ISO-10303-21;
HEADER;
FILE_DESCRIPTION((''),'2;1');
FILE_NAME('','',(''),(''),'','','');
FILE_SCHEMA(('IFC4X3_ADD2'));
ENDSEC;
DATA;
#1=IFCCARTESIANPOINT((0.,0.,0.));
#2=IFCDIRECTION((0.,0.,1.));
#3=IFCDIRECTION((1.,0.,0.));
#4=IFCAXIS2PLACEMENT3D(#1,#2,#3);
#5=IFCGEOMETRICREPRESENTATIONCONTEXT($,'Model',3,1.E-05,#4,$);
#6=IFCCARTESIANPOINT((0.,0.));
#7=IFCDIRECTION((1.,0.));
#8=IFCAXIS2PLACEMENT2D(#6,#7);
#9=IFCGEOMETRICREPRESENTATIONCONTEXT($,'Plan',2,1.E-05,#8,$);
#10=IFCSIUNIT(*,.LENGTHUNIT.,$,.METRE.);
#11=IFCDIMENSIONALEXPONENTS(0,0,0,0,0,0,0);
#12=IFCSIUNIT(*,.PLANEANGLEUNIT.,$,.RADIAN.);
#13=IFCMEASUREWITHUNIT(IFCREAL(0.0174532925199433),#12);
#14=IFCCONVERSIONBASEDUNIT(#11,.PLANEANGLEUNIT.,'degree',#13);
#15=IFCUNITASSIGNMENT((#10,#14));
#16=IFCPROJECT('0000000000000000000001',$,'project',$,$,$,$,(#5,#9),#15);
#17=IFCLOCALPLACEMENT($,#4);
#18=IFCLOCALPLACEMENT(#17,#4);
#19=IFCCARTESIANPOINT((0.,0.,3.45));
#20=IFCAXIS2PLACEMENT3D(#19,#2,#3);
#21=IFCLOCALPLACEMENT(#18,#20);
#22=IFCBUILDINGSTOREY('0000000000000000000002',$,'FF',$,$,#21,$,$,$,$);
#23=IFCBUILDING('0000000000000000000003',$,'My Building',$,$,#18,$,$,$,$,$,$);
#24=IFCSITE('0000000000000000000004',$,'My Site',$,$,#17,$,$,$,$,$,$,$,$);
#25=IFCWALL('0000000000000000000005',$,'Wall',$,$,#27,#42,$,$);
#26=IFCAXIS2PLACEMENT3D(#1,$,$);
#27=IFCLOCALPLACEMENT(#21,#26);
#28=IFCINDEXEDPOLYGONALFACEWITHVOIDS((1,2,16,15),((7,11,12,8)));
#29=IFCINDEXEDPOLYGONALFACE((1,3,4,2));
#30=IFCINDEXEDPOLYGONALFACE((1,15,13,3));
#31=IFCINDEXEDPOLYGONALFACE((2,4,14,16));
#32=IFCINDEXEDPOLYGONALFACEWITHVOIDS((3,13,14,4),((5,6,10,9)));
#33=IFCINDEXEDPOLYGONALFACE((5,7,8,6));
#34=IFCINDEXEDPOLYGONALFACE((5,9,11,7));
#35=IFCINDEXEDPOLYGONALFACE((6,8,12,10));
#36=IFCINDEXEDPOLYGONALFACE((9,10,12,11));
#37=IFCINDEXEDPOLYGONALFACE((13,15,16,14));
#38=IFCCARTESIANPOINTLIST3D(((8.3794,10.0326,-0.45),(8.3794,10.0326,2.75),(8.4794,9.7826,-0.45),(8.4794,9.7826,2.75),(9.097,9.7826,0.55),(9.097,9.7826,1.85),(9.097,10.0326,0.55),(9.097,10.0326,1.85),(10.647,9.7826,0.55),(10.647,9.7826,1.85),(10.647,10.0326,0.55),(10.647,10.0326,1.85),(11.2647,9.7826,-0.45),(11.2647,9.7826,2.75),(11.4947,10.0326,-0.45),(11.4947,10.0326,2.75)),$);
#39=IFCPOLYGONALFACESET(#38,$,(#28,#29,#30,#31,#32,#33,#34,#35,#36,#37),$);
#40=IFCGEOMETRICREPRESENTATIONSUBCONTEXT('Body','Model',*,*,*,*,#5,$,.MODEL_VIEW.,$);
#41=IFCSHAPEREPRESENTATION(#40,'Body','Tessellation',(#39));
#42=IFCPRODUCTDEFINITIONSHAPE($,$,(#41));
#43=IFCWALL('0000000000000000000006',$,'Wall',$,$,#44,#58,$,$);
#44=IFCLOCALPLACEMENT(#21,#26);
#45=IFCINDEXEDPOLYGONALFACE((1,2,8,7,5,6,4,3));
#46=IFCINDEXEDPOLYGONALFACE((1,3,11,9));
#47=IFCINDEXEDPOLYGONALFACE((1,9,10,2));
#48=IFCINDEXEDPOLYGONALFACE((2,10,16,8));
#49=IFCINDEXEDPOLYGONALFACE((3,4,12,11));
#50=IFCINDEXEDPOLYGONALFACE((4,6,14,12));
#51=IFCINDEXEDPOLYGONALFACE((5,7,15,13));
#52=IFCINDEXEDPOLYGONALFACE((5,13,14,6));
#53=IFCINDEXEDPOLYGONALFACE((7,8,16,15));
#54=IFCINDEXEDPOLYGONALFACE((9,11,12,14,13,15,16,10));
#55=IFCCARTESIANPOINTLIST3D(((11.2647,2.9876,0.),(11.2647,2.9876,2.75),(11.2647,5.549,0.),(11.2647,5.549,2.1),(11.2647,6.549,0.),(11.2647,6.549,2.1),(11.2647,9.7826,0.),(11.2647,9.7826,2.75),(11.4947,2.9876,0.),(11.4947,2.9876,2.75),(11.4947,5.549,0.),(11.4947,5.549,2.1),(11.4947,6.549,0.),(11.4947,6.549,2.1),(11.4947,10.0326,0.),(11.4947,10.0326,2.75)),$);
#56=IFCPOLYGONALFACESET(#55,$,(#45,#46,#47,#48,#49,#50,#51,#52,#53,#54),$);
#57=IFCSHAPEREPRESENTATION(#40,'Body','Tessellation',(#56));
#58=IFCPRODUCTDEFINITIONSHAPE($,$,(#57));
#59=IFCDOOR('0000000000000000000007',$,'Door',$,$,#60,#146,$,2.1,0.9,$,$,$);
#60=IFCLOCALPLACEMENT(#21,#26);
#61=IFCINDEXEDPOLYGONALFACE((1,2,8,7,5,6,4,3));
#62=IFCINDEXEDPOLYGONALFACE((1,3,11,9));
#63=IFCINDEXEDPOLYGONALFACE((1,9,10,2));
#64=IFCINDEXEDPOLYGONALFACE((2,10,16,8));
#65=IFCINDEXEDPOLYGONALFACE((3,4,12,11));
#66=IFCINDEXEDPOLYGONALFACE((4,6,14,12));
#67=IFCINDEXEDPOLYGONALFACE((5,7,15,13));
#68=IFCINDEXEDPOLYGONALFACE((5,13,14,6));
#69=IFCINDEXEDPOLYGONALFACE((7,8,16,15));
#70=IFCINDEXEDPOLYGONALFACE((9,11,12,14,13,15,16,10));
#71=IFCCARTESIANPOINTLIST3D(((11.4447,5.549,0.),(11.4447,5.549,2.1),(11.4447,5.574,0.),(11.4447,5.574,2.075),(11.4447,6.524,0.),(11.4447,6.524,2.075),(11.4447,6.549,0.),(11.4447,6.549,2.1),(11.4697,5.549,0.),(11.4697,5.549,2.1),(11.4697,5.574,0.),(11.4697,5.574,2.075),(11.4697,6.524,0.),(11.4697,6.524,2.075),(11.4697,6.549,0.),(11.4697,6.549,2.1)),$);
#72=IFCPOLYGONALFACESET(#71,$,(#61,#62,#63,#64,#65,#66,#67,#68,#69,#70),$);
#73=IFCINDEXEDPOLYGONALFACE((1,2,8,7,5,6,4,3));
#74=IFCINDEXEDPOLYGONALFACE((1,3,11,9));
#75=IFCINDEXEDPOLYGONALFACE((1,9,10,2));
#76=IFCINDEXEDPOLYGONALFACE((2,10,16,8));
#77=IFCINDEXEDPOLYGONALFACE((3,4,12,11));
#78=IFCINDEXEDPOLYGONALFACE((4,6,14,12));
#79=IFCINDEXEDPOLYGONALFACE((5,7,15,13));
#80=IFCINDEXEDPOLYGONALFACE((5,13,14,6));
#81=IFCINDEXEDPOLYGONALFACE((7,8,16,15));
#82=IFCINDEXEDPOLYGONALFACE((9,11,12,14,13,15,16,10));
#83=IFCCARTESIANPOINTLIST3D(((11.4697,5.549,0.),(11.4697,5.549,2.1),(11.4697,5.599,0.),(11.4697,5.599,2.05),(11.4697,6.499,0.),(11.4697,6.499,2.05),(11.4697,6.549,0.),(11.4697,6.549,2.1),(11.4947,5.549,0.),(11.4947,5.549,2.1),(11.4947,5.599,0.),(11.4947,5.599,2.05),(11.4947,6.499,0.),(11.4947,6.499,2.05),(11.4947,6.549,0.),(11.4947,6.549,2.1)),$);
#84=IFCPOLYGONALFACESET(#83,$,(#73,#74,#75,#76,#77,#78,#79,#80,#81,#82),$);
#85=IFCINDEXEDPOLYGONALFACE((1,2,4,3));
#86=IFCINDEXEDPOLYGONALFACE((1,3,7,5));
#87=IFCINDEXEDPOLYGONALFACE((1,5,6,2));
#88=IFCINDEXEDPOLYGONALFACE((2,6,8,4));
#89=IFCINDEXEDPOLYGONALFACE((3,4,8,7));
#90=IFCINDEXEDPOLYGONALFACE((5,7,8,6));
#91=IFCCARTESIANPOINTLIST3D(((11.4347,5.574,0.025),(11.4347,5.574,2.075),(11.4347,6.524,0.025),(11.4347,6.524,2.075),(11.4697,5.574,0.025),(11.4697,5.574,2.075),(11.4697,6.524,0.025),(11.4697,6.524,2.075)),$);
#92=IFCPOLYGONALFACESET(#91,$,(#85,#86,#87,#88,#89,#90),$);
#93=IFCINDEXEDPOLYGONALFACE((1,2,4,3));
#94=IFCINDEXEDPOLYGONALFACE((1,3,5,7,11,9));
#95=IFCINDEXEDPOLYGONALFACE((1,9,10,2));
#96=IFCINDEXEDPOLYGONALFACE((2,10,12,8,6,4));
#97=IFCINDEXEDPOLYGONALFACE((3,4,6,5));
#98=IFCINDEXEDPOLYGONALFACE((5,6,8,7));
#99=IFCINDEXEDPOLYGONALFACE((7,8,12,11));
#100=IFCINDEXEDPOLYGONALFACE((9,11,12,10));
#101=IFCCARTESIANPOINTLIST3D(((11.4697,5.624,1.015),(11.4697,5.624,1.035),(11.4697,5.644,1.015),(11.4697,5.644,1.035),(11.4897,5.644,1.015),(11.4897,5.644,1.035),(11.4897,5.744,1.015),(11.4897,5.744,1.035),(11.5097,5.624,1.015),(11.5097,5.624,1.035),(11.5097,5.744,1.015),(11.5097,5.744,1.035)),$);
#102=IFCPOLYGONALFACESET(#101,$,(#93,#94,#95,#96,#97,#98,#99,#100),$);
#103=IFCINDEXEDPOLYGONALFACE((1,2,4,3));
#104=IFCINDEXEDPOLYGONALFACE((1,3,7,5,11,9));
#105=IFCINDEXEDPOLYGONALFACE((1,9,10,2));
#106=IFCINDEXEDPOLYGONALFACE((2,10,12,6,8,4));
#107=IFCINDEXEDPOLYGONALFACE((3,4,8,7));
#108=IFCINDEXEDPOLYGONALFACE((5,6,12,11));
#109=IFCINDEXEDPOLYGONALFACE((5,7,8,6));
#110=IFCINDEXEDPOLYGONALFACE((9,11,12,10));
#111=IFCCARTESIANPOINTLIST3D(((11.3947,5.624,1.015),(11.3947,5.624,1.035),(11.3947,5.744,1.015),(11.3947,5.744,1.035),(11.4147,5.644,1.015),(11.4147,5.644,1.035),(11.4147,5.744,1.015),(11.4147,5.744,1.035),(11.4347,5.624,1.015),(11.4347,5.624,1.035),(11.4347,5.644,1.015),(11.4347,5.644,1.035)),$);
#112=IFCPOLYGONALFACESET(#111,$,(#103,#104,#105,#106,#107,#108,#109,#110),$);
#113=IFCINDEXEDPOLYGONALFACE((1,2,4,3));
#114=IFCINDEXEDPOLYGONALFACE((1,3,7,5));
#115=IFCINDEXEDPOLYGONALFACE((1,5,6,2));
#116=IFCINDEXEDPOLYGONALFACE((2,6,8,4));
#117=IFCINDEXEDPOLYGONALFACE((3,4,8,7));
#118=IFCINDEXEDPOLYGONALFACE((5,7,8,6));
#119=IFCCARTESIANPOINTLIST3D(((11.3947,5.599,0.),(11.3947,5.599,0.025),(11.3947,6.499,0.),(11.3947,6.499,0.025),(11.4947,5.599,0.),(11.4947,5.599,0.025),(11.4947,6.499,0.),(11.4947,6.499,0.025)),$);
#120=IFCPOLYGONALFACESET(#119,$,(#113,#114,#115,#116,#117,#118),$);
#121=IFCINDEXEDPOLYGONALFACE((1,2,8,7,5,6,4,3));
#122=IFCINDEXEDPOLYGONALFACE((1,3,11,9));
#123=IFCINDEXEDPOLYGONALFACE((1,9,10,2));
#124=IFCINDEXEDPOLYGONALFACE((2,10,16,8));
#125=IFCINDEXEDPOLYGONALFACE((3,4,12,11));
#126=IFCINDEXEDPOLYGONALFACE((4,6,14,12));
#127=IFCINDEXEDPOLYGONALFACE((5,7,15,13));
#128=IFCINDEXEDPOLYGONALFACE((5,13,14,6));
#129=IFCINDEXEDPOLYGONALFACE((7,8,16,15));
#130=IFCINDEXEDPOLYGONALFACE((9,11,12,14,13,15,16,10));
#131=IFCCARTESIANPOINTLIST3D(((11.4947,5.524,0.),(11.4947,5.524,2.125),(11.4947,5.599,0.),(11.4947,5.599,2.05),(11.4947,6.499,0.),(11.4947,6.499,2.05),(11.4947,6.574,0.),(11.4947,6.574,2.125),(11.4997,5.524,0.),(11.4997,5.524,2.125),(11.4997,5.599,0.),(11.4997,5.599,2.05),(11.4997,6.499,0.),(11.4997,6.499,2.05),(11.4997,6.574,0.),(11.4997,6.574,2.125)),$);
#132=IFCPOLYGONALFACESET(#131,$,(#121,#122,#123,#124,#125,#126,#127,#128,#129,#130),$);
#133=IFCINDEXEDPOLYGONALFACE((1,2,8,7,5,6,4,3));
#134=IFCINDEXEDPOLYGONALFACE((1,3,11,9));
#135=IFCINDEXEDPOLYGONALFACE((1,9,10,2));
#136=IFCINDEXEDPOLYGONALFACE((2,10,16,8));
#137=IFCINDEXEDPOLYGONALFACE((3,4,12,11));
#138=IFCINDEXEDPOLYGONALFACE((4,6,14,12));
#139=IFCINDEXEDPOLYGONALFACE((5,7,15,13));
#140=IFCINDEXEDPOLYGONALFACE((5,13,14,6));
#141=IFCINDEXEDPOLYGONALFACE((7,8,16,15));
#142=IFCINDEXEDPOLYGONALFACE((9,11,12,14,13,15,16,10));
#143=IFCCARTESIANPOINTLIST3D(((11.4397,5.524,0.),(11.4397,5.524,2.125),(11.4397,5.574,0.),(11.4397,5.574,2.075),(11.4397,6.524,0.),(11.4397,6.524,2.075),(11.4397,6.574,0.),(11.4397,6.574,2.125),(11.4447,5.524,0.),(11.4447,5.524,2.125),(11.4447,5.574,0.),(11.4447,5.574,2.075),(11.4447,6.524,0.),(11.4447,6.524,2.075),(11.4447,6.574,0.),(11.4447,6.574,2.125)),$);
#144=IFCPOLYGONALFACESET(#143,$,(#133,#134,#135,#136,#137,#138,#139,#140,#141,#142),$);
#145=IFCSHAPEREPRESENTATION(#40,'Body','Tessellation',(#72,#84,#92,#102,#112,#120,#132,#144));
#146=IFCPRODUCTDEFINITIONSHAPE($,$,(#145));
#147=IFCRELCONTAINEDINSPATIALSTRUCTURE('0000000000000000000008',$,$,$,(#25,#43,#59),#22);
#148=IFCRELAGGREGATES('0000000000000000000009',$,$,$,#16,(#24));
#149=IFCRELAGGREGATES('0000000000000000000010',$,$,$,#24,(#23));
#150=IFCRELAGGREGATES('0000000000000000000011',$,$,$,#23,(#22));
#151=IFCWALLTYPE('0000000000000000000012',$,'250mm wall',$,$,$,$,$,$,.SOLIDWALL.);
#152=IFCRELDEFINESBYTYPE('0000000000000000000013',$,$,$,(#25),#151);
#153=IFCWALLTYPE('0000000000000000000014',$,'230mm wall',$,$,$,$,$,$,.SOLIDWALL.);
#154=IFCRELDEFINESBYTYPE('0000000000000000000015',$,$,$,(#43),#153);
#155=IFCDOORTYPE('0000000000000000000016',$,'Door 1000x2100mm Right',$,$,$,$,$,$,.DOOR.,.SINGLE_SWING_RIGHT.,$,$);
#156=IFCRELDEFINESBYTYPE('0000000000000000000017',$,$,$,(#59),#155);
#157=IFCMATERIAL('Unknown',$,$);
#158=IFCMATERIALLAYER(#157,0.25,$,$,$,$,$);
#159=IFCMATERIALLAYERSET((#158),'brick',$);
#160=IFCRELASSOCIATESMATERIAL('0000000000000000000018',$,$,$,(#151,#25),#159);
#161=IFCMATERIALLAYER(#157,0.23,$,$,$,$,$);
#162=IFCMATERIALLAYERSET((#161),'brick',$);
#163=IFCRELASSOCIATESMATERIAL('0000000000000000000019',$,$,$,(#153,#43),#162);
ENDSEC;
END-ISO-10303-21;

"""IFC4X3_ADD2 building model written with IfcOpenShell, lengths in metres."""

from ifc_helpers import new_model, entity, si_unit, converted_unit, frame, origin_with_axes, origin_2d_with_axis, place, context, subcontext, project, spatial, line, indexed_curve, outline, extrude, shape, source, transform, mapped, material, layer, layer_set, layer_usage, type_object, type_shapes, element, fill, save


model = new_model("IFC4X3_ADD2")

# Units and contexts
model_context = context("Model", 3, precision=1e-05, world=origin_with_axes())
plan_context = context("Plan", 2, precision=1e-05, world=origin_2d_with_axis())
body_context_1 = subcontext(model_context, "Body", "Model", "MODEL_VIEW")
body_context_2 = subcontext(plan_context, "Body", "Plan", "PLAN_VIEW")
ifc_project = project(units=[si_unit("LENGTHUNIT", "METRE"), converted_unit("PLANEANGLEUNIT", "degree", entity("IfcReal", 0.0174532925199433), si_unit("PLANEANGLEUNIT", "RADIAN"), dimensions=[0, 0, 0, 0, 0, 0, 0])], contexts=[model_context, plan_context])

# Site, building, storey
site_placement = place(None, origin_with_axes())
site = spatial("IfcSite", under=ifc_project, at=site_placement, Name="My Site")
building_placement = place(site_placement, origin_with_axes())
building = spatial("IfcBuilding", under=site, at=building_placement, Name="My Building")
storey_placement = place(building_placement, frame((0.0, 0.0, 3.45), z_axis=(0.0, 0.0, 1.0), x_axis=(1.0, 0.0, 0.0)))
storey = spatial("IfcBuildingStorey", under=building, at=storey_placement, Name="FF")

# Wall, opening
ifc_material = material(Name="Unknown")
ifc_layer_1 = layer(ifc_material, 0.25)
ifc_layer_set_1 = layer_set([ifc_layer_1], Name="brick")
ifc_layer_usage_1 = layer_usage(ifc_layer_set_1, "AXIS2", "POSITIVE", 0.0)
wall_type_1 = type_object("IfcWallType", Name="250mm wall", PredefinedType="SOLIDWALL", material=ifc_layer_set_1)
wall_1_placement = place(storey_placement, frame((8.4794, 9.7826, -0.45), z_axis=(0.0, 0.0, 1.0), x_axis=(1.0, 0.0, 0.0)))
wall_1 = element("IfcWall", 1, at=wall_1_placement, inside=storey, type_object=wall_type_1, material=ifc_layer_usage_1, Name="Wall", context=body_context_1, shape_type="SweptSolid", body=[
    extrude(outline(indexed_curve([(0.0, 0.0), (-0.1, 0.25), (3.0153, 0.25), (2.7853, 0.0)], segments=[line(1, 2, 3, 4, 1)])), origin_with_axes(), (0.0, 0.0, 1.0), 3.2),
])
shared_shape_1 = source(origin_with_axes(), body_context_1, "Body", "SweptSolid", [
    extrude(outline(indexed_curve([(0.0, 0.0), (1.55, 0.0), (1.55, 1.3), (0.0, 1.3)], segments=[line(1, 2, 3, 4, 1)])), frame((-0.775, -0.6, 0.0), z_axis=(0.0, -1.0, 0.0), x_axis=(1.0, 0.0, 0.0)), (0.0, 0.0, -1.0), 1.2),
])
opening_1_placement = place(wall_1_placement, frame((1.3926, 0.0, 1.0), z_axis=(0.0, 0.0, 1.0), x_axis=(1.0, 0.0, 0.0)))
element("IfcOpeningElement", 2, at=opening_1_placement, cuts=wall_1, PredefinedType="OPENING", context=body_context_1, shape_type="MappedRepresentation", body=[
    mapped(shared_shape_1, transform((0.0, 0.0, 0.0), x_axis=(1.0, 0.0, 0.0), y_axis=(0.0, 1.0, 0.0), z_axis=(0.0, 0.0, 1.0), scale=1.0)),
])

# Wall, opening, door
ifc_layer_2 = layer(ifc_material, 0.23)
ifc_layer_set_2 = layer_set([ifc_layer_2], Name="brick")
ifc_layer_usage_2 = layer_usage(ifc_layer_set_2, "AXIS2", "POSITIVE", 0.0)
wall_type_2 = type_object("IfcWallType", Name="230mm wall", PredefinedType="SOLIDWALL", material=ifc_layer_set_2)
wall_2_placement = place(storey_placement, frame((11.4947, 2.9876, 0.0), z_axis=(0.0, 0.0, 1.0), x_axis=(0.0, 1.0, 0.0)))
wall_2 = element("IfcWall", 3, at=wall_2_placement, inside=storey, type_object=wall_type_2, material=ifc_layer_usage_2, Name="Wall", context=body_context_1, shape_type="SweptSolid", body=[
    extrude(outline(indexed_curve([(0.0, 0.0), (0.0, 0.23), (6.795, 0.23), (7.045, 0.0)], segments=[line(1, 2, 3, 4, 1)])), origin_with_axes(), (0.0, 0.0, 1.0), 2.75),
])
shared_shape_2 = source(origin_with_axes(), body_context_1, "Body", "SolidModel", [
    extrude(outline(indexed_curve([(0.0, 0.0), (1.0, 0.0), (1.0, 2.1), (0.0, 2.1)], segments=[line(1, 2, 3, 4, 1)])), frame((0.0, -0.6, 0.0), z_axis=(0.0, -1.0, 0.0), x_axis=(1.0, 0.0, 0.0)), (0.0, 0.0, -1.0), 1.2),
])
opening_2_placement = place(wall_2_placement, frame((2.5614, 0.0, 0.0), z_axis=(0.0, 0.0, 1.0), x_axis=(1.0, 0.0, 0.0)))
opening_2 = element("IfcOpeningElement", 4, at=opening_2_placement, cuts=wall_2, PredefinedType="OPENING", context=body_context_1, shape_type="MappedRepresentation", body=[
    mapped(shared_shape_2, transform((0.0, 0.0, 0.0), x_axis=(1.0, 0.0, 0.0), y_axis=(0.0, 1.0, 0.0), z_axis=(0.0, 0.0, 1.0), scale=1.0)),
])
door_type_1 = type_object("IfcDoorType", Name="Door 1000x2100mm Right", OperationType="SINGLE_SWING_RIGHT", PredefinedType="DOOR")
shared_shape_3 = source(origin_with_axes(), body_context_1, "Body", "SweptSolid", [
    extrude(outline(indexed_curve([(0.0, 0.0), (0.0, 2.1), (1.0, 2.1), (1.0, 0.0), (0.975, 0.0), (0.975, 2.075), (0.025, 2.075), (0.025, 0.0)], segments=[line(1, 2, 3, 4, 5, 6, 7, 8, 1)])), frame((0.0, 0.025, 0.0), z_axis=(0.0, -1.0, 0.0), x_axis=(1.0, 0.0, 0.0)), (0.0, 0.0, -1.0), 0.025),
    extrude(outline(indexed_curve([(0.0, 0.0), (0.0, 2.1), (1.0, 2.1), (1.0, 0.0), (0.95, 0.0), (0.95, 2.05), (0.05, 2.05), (0.05, 0.0)], segments=[line(1, 2, 3, 4, 5, 6, 7, 8, 1)])), frame((0.0, 0.0, 0.0), z_axis=(0.0, -1.0, 0.0), x_axis=(1.0, 0.0, 0.0)), (0.0, 0.0, -1.0), 0.025),
    extrude(outline(indexed_curve([(0.0, 0.0), (0.95, 0.0), (0.95, 0.035), (0.0, 0.035)], segments=[line(1, 2, 3, 4, 1)])), frame((0.025, 0.025, 0.025), z_axis=(0.0, 0.0, 1.0), x_axis=(1.0, 0.0, 0.0)), (0.0, 0.0, 1.0), 2.05),
    extrude(outline(indexed_curve([(0.0, 0.0), (0.0, -0.04), (0.12, -0.04), (0.12, -0.02), (0.02, -0.02), (0.02, 0.0)], segments=[line(1, 2, 3, 4, 5, 6, 1)])), frame((0.075, 0.025, 1.015), z_axis=(0.0, 0.0, 1.0), x_axis=(1.0, 0.0, 0.0)), (0.0, 0.0, 1.0), 0.02),
    extrude(outline(indexed_curve([(0.0, 0.0), (0.0, 0.04), (0.12, 0.04), (0.12, 0.02), (0.02, 0.02), (0.02, 0.0)], segments=[line(1, 2, 3, 4, 5, 6, 1)])), frame((0.075, 0.06, 1.015), z_axis=(0.0, 0.0, 1.0), x_axis=(1.0, 0.0, 0.0)), (0.0, 0.0, 1.0), 0.02),
    extrude(outline(indexed_curve([(0.0, 0.0), (0.9, 0.0), (0.9, 0.1), (0.0, 0.1)], segments=[line(1, 2, 3, 4, 1)])), frame((0.05, 0.0, 0.0), z_axis=(0.0, 0.0, 1.0), x_axis=(1.0, 0.0, 0.0)), (0.0, 0.0, 1.0), 0.025),
    extrude(outline(indexed_curve([(0.0, 0.0), (0.0, 2.125), (1.05, 2.125), (1.05, 0.0), (0.975, 0.0), (0.975, 2.05), (0.075, 2.05), (0.075, 0.0)], segments=[line(1, 2, 3, 4, 5, 6, 7, 8, 1)])), frame((-0.025, -0.005, 0.0), z_axis=(0.0, -1.0, 0.0), x_axis=(1.0, 0.0, 0.0)), (0.0, 0.0, -1.0), 0.005),
    extrude(outline(indexed_curve([(0.0, 0.0), (0.0, 2.125), (1.05, 2.125), (1.05, 0.0), (1.0, 0.0), (1.0, 2.075), (0.05, 2.075), (0.05, 0.0)], segments=[line(1, 2, 3, 4, 5, 6, 7, 8, 1)])), frame((-0.025, 0.05, 0.0), z_axis=(0.0, -1.0, 0.0), x_axis=(1.0, 0.0, 0.0)), (0.0, 0.0, -1.0), 0.005),
])
shared_shape_4 = source(origin_with_axes(), body_context_2, "Body", "Curve2D", [
    entity("IfcIndexedPolyCurve", entity("IfcCartesianPointList2D", [[0.0, 0.0], [0.0, 0.05], [0.025, 0.05], [0.025, 0.025], [0.05, 0.025], [0.05, 0.0]]), [entity("IfcLineIndex", [1, 2, 3, 4, 5, 6, 1])]),
    entity("IfcIndexedPolyCurve", entity("IfcCartesianPointList2D", [[1.0, 0.0], [1.0, 0.05], [0.975, 0.05], [0.975, 0.025], [0.95, 0.025], [0.95, 0.0]]), [entity("IfcLineIndex", [1, 2, 3, 4, 5, 6, 1])]),
    entity("IfcTrimmedCurve", entity("IfcEllipse", entity("IfcAxis2Placement2D", entity("IfcCartesianPoint", [0.94, 0.05]), entity("IfcDirection", [1.0, 0.0])), 0.915, 0.95), [entity("IfcCartesianPoint", [0.94, 1.0])], [entity("IfcCartesianPoint", [0.025, 0.05])], True, "CARTESIAN"),
    entity("IfcIndexedPolyCurve", entity("IfcCartesianPointList2D", [[0.975, 0.05], [0.94, 0.05], [0.94, 1.0], [0.975, 1.0]]), [entity("IfcLineIndex", [1, 2, 3, 4, 1])]),
])
type_shapes(door_type_1, [shared_shape_3, shared_shape_4])
door_1_placement = place(opening_2_placement, frame((0.0, 0.0, 0.0), z_axis=(0.0, 0.0, 1.0), x_axis=(1.0, 0.0, 0.0)))
door_1 = element("IfcDoor", 5, at=door_1_placement, inside=storey, type_object=door_type_1, Name="Door", OverallHeight=2.1, OverallWidth=0.9, shapes=[
    shape(body_context_1, "Body", "MappedRepresentation", [mapped(shared_shape_3, transform((0.0, 0.0, 0.0), x_axis=(1.0, 0.0, 0.0), y_axis=(0.0, 1.0, 0.0), z_axis=(0.0, 0.0, 1.0), scale=1.0))]),
    shape(body_context_2, "Body", "MappedRepresentation", [mapped(shared_shape_4, transform((0.0, 0.0, 0.0), x_axis=(1.0, 0.0, 0.0), y_axis=(0.0, 1.0, 0.0), z_axis=(0.0, 0.0, 1.0), scale=1.0))]),
])
fill(opening_2, door_1)

save(model, "model.ifc")
